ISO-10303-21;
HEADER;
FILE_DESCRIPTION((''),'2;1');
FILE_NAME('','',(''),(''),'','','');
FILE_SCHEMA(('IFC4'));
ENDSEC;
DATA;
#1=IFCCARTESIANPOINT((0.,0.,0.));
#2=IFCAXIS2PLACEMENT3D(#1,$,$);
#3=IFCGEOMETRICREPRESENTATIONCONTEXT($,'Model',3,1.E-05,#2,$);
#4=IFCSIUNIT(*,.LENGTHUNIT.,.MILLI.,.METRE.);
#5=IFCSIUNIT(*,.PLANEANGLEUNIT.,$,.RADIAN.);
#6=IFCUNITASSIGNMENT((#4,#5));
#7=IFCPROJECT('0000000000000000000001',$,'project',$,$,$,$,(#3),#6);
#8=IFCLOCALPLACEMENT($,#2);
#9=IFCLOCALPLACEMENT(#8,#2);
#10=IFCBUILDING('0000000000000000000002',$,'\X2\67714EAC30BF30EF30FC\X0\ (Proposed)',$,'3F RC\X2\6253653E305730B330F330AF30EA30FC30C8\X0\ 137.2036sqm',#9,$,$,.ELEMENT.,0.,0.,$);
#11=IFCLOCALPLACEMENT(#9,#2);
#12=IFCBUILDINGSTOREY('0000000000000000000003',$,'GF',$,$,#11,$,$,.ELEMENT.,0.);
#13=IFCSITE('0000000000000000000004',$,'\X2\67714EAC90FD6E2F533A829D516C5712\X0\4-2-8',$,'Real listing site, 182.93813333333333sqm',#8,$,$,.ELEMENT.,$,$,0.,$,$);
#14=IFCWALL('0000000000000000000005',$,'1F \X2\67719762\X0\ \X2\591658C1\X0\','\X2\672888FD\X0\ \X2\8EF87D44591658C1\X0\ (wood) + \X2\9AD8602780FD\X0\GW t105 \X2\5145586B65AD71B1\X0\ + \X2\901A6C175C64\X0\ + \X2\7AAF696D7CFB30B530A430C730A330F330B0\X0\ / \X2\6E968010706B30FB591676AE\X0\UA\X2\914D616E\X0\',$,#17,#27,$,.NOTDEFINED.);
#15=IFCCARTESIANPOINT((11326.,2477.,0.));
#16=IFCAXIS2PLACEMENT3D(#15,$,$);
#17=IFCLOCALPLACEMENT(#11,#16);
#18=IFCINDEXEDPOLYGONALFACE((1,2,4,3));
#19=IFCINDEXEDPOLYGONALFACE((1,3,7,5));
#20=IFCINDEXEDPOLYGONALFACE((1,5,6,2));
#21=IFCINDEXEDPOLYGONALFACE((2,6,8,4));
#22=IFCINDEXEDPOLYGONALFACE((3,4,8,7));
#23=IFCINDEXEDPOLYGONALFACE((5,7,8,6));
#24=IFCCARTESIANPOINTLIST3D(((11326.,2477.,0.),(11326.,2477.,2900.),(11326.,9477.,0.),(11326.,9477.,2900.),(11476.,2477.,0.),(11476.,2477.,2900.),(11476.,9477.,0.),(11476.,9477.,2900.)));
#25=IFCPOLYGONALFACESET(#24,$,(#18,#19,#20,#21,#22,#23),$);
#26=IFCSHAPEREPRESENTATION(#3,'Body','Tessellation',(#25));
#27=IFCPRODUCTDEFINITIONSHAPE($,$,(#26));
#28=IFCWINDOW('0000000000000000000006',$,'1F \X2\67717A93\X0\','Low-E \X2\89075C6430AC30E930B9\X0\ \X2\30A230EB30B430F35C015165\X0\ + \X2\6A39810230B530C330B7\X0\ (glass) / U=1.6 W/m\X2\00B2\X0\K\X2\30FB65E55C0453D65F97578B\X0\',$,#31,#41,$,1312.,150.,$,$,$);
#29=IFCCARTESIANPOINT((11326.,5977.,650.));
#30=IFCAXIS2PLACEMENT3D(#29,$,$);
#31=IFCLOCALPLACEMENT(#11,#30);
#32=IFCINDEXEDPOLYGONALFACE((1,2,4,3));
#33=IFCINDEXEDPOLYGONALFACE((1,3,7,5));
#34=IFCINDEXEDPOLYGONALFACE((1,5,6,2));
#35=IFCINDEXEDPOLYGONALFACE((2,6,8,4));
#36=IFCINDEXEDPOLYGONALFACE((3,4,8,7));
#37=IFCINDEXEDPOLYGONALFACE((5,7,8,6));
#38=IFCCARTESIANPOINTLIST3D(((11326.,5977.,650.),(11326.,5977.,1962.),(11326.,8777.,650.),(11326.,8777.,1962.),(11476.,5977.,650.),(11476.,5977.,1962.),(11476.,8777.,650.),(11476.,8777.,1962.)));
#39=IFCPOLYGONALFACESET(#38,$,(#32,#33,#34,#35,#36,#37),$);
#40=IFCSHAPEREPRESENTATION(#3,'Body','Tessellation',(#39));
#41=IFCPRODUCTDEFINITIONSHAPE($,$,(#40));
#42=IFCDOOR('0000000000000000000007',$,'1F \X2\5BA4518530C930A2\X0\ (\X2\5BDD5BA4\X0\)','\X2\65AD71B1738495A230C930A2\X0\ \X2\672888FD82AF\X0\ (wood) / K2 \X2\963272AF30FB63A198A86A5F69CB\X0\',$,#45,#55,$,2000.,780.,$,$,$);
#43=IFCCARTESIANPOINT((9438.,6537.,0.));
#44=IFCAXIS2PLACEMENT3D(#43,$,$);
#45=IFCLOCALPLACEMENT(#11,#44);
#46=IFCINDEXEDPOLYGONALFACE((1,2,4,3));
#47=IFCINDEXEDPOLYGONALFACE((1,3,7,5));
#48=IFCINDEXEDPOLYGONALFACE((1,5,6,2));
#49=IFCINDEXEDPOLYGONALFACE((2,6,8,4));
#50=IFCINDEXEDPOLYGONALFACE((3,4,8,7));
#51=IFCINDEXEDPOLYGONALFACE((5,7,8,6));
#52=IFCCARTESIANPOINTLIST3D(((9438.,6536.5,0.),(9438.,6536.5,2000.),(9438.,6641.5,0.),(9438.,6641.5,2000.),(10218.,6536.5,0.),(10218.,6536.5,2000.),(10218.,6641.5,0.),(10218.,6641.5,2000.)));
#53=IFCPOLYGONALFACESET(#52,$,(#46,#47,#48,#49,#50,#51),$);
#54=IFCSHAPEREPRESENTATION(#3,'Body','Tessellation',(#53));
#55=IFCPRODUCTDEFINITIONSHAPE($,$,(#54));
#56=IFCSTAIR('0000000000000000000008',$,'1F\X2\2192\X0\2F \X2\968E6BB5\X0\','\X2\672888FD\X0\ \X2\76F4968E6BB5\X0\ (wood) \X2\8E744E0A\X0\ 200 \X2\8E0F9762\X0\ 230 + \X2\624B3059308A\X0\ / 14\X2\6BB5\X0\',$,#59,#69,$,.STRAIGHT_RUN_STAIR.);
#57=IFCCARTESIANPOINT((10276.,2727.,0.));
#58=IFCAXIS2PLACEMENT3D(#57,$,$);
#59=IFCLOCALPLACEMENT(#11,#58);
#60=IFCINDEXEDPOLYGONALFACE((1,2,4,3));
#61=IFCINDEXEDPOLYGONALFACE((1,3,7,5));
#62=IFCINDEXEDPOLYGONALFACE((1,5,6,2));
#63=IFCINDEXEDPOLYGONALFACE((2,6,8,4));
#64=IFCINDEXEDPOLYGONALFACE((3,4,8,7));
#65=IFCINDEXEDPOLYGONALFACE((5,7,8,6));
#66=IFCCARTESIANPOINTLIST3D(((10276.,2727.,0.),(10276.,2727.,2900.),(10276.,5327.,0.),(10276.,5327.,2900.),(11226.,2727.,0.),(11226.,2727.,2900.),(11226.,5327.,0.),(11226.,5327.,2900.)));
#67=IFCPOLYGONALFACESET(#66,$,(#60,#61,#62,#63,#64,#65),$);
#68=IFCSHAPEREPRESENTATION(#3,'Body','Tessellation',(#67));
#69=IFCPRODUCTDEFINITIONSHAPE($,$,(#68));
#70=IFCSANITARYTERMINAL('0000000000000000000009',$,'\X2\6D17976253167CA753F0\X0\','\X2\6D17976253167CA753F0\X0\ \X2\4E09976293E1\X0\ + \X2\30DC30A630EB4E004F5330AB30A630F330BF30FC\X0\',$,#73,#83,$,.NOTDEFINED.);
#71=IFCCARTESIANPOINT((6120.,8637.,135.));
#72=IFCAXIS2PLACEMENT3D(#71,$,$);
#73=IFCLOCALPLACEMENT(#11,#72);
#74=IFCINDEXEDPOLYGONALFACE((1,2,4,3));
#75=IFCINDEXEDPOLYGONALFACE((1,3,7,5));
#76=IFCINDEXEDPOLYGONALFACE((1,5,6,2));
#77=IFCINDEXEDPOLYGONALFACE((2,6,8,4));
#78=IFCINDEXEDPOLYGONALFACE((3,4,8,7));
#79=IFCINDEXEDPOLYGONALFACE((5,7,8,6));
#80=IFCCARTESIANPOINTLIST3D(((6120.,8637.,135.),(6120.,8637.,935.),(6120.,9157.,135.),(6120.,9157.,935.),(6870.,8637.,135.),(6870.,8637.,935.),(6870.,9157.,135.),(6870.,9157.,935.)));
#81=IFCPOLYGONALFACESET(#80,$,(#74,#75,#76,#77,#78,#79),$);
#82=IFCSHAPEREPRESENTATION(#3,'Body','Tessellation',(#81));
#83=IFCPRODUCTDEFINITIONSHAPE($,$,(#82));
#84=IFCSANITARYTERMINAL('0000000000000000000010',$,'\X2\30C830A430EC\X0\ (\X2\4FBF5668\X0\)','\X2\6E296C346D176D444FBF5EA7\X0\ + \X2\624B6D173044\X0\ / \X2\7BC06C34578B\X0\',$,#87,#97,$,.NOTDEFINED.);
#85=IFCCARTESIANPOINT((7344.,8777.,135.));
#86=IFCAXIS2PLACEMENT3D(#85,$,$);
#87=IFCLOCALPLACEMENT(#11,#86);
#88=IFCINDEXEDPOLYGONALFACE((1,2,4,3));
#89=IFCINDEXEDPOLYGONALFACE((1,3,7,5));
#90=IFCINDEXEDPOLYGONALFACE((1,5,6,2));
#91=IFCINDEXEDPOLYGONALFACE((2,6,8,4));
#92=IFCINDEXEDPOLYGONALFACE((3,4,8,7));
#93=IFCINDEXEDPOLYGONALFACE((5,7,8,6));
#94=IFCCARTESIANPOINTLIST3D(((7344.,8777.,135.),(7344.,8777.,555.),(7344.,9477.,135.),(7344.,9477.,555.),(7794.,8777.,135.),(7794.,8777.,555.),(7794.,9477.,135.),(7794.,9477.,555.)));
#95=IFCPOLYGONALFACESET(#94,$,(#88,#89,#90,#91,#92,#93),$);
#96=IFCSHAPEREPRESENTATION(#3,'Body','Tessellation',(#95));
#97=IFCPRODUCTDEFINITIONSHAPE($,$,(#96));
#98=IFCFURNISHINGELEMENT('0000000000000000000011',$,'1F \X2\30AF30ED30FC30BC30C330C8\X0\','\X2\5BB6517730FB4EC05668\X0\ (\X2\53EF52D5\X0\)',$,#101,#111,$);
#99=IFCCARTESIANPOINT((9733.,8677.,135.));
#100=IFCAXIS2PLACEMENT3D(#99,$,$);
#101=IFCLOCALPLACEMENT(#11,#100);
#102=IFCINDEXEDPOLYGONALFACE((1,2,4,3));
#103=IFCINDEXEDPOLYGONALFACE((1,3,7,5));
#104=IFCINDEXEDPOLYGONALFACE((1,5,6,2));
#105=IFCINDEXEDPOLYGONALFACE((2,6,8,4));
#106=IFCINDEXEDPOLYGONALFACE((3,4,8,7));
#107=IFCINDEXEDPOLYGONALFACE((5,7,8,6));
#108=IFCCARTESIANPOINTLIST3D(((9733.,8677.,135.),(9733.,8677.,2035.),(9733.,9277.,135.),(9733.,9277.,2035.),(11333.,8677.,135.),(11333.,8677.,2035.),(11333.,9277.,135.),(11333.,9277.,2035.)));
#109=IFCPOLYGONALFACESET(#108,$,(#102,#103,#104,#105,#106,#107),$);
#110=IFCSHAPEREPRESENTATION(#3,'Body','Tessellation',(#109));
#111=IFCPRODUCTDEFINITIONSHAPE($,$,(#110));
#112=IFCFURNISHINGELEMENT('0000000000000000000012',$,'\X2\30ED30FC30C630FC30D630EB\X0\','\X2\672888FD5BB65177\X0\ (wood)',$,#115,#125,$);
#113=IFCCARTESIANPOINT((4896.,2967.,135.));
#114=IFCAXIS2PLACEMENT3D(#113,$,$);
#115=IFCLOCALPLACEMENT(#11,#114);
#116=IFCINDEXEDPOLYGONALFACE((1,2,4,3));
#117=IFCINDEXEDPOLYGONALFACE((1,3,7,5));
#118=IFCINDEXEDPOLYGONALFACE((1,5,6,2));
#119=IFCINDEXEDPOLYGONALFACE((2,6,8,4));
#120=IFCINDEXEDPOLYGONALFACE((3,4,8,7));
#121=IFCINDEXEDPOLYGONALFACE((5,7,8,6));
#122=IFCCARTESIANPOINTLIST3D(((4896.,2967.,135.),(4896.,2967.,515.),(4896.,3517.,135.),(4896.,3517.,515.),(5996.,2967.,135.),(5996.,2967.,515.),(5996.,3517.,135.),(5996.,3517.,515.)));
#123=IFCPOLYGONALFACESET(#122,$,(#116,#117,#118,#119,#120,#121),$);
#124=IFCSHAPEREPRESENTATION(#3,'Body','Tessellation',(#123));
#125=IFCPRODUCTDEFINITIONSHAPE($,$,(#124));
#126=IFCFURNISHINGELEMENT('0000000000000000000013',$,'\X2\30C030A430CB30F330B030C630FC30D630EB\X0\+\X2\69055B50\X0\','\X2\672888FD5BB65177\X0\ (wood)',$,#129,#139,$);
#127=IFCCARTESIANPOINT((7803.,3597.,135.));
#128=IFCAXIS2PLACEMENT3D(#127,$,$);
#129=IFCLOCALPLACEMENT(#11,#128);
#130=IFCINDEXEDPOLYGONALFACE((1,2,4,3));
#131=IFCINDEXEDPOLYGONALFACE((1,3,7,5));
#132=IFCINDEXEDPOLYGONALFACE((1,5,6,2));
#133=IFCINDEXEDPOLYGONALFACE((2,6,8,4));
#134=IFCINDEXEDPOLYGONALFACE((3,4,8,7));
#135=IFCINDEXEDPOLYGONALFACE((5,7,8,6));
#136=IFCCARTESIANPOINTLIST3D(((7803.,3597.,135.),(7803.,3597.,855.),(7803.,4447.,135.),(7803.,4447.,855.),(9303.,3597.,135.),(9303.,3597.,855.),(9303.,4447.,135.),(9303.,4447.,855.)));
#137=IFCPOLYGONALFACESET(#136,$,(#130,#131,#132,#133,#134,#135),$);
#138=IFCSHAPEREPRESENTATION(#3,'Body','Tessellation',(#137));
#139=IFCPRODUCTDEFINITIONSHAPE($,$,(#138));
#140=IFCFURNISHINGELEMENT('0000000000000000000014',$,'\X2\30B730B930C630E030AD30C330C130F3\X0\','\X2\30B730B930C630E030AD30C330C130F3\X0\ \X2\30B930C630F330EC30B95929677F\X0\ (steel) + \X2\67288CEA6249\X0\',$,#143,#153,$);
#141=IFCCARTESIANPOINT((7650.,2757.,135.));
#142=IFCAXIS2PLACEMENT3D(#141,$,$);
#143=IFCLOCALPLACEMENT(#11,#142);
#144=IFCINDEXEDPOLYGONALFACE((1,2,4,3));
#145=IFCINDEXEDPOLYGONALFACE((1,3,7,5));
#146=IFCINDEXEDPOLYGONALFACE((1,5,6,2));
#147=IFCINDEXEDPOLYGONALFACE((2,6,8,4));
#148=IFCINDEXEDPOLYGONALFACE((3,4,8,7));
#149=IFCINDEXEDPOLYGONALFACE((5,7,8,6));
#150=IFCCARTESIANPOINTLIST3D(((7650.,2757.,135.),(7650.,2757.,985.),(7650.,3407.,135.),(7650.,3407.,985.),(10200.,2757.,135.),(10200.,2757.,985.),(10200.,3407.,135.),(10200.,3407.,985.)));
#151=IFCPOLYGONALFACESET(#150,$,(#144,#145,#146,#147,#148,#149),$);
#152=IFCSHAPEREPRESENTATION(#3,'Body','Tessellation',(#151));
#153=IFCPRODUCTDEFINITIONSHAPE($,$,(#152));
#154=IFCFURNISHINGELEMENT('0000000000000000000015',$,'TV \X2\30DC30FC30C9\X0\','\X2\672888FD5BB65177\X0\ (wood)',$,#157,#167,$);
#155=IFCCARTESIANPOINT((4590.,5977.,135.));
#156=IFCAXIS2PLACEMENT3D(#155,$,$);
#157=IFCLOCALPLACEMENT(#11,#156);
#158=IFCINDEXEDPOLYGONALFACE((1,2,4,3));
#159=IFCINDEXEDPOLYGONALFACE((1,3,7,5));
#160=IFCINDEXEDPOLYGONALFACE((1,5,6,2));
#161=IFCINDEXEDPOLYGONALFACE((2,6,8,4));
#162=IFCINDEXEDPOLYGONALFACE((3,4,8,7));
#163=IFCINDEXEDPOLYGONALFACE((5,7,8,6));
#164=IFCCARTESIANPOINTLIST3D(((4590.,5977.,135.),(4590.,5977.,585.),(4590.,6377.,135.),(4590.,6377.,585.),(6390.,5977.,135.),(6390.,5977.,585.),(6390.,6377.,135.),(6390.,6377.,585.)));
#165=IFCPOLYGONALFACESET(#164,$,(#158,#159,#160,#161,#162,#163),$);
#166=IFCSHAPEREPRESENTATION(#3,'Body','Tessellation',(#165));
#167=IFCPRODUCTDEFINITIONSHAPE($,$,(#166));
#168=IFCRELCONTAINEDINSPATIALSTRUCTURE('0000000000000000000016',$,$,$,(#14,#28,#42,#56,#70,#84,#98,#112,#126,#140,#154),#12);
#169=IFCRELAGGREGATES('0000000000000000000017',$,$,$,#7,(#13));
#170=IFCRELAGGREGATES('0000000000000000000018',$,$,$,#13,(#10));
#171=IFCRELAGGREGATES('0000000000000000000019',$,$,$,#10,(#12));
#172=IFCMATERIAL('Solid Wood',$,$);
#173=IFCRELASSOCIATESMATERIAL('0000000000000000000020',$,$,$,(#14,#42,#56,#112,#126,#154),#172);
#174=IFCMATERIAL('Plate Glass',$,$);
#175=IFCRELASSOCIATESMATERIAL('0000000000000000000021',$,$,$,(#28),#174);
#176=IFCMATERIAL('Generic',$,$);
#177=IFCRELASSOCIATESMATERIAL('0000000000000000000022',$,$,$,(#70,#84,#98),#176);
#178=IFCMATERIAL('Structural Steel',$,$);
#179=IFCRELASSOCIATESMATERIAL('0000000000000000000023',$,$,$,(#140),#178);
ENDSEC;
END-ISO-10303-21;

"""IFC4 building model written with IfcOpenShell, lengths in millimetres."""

from ifc_helpers import new_model, si_unit, frame, frame_2d, origin, place, context, project, spatial, rectangle, extrude, material, element, fill, save


model = new_model("IFC4")

# Units and contexts
model_context = context("Model", 3, precision=1e-05, world=origin())
ifc_project = project(units=[si_unit("LENGTHUNIT", "METRE", prefix="MILLI"), si_unit("PLANEANGLEUNIT", "RADIAN")], contexts=[model_context])

# Site, building, storey
site_placement = place(None, origin())
site = spatial("IfcSite", under=ifc_project, at=site_placement, Name="東京都港区芝公園4-2-8", ObjectType="Real listing site, 182.93813333333333sqm", CompositionType="ELEMENT", RefElevation=0.0)
building_placement = place(site_placement, origin())
building = spatial("IfcBuilding", under=site, at=building_placement, Name="東京タワー (Proposed)", ObjectType="3F RC打放しコンクリート 137.2036sqm", CompositionType="ELEMENT", ElevationOfRefHeight=0.0, ElevationOfTerrain=0.0)
storey_placement = place(building_placement, origin())
storey = spatial("IfcBuildingStorey", under=building, at=storey_placement, Name="GF", CompositionType="ELEMENT", Elevation=0.0)

# Wall, opening, window
ifc_material_1 = material(Name="Solid Wood")
wall_1_placement = place(storey_placement, frame((11326.0, 2477.0, 0.0)))
wall_1 = element("IfcWall", 1, at=wall_1_placement, inside=storey, material=ifc_material_1, Name="1F 東面 外壁", Description="木製 軸組外壁 (wood) + 高性能GW t105 充填断熱 + 通気層 + 窯業系サイディング / 準耐火・外皮UA配慮", PredefinedType="NOTDEFINED", context=model_context, shape_type="SweptSolid", body=[
    extrude(rectangle(XDim=150.0, YDim=7000.0, at=frame_2d((75.0, 3500.0))), frame((11326.0, 2477.0, 0.0)), (0.0, 0.0, 1.0), 2900.0),
])
opening_placement = place(storey_placement, frame((11326.0, 5977.0, 650.0)))
opening = element("IfcOpeningElement", 2, at=opening_placement, cuts=wall_1, PredefinedType="NOTDEFINED", context=model_context, shape_type="SweptSolid", body=[
    extrude(rectangle(XDim=150.0, YDim=2800.0, at=frame_2d((75.0, 1400.0))), frame((11326.0, 5977.0, 650.0)), (0.0, 0.0, 1.0), 1312.0),
])
ifc_material_2 = material(Name="Plate Glass")
window_placement = place(storey_placement, frame((11326.0, 5977.0, 650.0)))
window = element("IfcWindow", 3, at=window_placement, inside=storey, material=ifc_material_2, Name="1F 東窓", Description="Low-E 複層ガラス アルゴン封入 + 樹脂サッシ (glass) / U=1.6 W/m²K・日射取得型", OverallHeight=1312.0, OverallWidth=150.0, context=model_context, shape_type="SweptSolid", body=[
    extrude(rectangle(XDim=150.0, YDim=2800.0, at=frame_2d((75.0, 1400.0))), frame((11326.0, 5977.0, 650.0)), (0.0, 0.0, 1.0), 1312.0),
])
fill(opening, window)

# Door
door_placement = place(storey_placement, frame((9438.0, 6537.0, 0.0)))
element("IfcDoor", 4, at=door_placement, inside=storey, material=ifc_material_1, Name="1F 室内ドア (寝室)", Description="断熱玄関ドア 木製芯 (wood) / K2 防犯・採風機構", OverallHeight=2000.0, OverallWidth=780.0, context=model_context, shape_type="SweptSolid", body=[
    extrude(rectangle(XDim=780.0, YDim=105.0, at=frame_2d((390.0, 52.0))), frame((9438.0, 6537.0, 0.0)), (0.0, 0.0, 1.0), 2000.0),
])

# Stair
stair_placement = place(storey_placement, frame((10276.0, 2727.0, 0.0)))
element("IfcStair", 5, at=stair_placement, inside=storey, material=ifc_material_1, Name="1F→2F 階段", Description="木製 直階段 (wood) 蹴上 200 踏面 230 + 手すり / 14段", PredefinedType="STRAIGHT_RUN_STAIR", context=model_context, shape_type="SweptSolid", body=[
    extrude(rectangle(XDim=950.0, YDim=2600.0, at=frame_2d((475.0, 1300.0))), frame((10276.0, 2727.0, 0.0)), (0.0, 0.0, 1.0), 2900.0),
])

# Sanitary terminals
ifc_material_3 = material(Name="Generic")
sanitary_terminal_1_placement = place(storey_placement, frame((6120.0, 8637.0, 135.0)))
element("IfcSanitaryTerminal", 6, at=sanitary_terminal_1_placement, inside=storey, material=ifc_material_3, Name="洗面化粧台", Description="洗面化粧台 三面鏡 + ボウル一体カウンター", PredefinedType="NOTDEFINED", context=model_context, shape_type="SweptSolid", body=[
    extrude(rectangle(XDim=750.0, YDim=520.0, at=frame_2d((375.0, 260.0))), frame((6120.0, 8637.0, 135.0)), (0.0, 0.0, 1.0), 800.0),
])
sanitary_terminal_2_placement = place(storey_placement, frame((7344.0, 8777.0, 135.0)))
element("IfcSanitaryTerminal", 7, at=sanitary_terminal_2_placement, inside=storey, material=ifc_material_3, Name="トイレ (便器)", Description="温水洗浄便座 + 手洗い / 節水型", PredefinedType="NOTDEFINED", context=model_context, shape_type="SweptSolid", body=[
    extrude(rectangle(XDim=450.0, YDim=700.0, at=frame_2d((225.0, 350.0))), frame((7344.0, 8777.0, 135.0)), (0.0, 0.0, 1.0), 420.0),
])

# Furnishing elements
furnishing_1_placement = place(storey_placement, frame((9733.0, 8677.0, 135.0)))
element("IfcFurnishingElement", 8, at=furnishing_1_placement, inside=storey, material=ifc_material_3, Name="1F クローゼット", Description="家具・什器 (可動)", context=model_context, shape_type="SweptSolid", body=[
    extrude(rectangle(XDim=1600.0, YDim=600.0, at=frame_2d((800.0, 300.0))), frame((9733.0, 8677.0, 135.0)), (0.0, 0.0, 1.0), 1900.0),
])
furnishing_2_placement = place(storey_placement, frame((4896.0, 2967.0, 135.0)))
element("IfcFurnishingElement", 9, at=furnishing_2_placement, inside=storey, material=ifc_material_1, Name="ローテーブル", Description="木製家具 (wood)", context=model_context, shape_type="SweptSolid", body=[
    extrude(rectangle(XDim=1100.0, YDim=550.0, at=frame_2d((550.0, 275.0))), frame((4896.0, 2967.0, 135.0)), (0.0, 0.0, 1.0), 380.0),
])
furnishing_3_placement = place(storey_placement, frame((7803.0, 3597.0, 135.0)))
element("IfcFurnishingElement", 10, at=furnishing_3_placement, inside=storey, material=ifc_material_1, Name="ダイニングテーブル+椅子", Description="木製家具 (wood)", context=model_context, shape_type="SweptSolid", body=[
    extrude(rectangle(XDim=1500.0, YDim=850.0, at=frame_2d((750.0, 425.0))), frame((7803.0, 3597.0, 135.0)), (0.0, 0.0, 1.0), 720.0),
])
ifc_material_4 = material(Name="Structural Steel")
furnishing_4_placement = place(storey_placement, frame((7650.0, 2757.0, 135.0)))
element("IfcFurnishingElement", 11, at=furnishing_4_placement, inside=storey, material=ifc_material_4, Name="システムキッチン", Description="システムキッチン ステンレス天板 (steel) + 木質扉", context=model_context, shape_type="SweptSolid", body=[
    extrude(rectangle(XDim=2550.0, YDim=650.0, at=frame_2d((1275.0, 325.0))), frame((7650.0, 2757.0, 135.0)), (0.0, 0.0, 1.0), 850.0),
])
furnishing_5_placement = place(storey_placement, frame((4590.0, 5977.0, 135.0)))
element("IfcFurnishingElement", 12, at=furnishing_5_placement, inside=storey, material=ifc_material_1, Name="TV ボード", Description="木製家具 (wood)", context=model_context, shape_type="SweptSolid", body=[
    extrude(rectangle(XDim=1800.0, YDim=400.0, at=frame_2d((900.0, 200.0))), frame((4590.0, 5977.0, 135.0)), (0.0, 0.0, 1.0), 450.0),
])

save(model, "model.ifc")
